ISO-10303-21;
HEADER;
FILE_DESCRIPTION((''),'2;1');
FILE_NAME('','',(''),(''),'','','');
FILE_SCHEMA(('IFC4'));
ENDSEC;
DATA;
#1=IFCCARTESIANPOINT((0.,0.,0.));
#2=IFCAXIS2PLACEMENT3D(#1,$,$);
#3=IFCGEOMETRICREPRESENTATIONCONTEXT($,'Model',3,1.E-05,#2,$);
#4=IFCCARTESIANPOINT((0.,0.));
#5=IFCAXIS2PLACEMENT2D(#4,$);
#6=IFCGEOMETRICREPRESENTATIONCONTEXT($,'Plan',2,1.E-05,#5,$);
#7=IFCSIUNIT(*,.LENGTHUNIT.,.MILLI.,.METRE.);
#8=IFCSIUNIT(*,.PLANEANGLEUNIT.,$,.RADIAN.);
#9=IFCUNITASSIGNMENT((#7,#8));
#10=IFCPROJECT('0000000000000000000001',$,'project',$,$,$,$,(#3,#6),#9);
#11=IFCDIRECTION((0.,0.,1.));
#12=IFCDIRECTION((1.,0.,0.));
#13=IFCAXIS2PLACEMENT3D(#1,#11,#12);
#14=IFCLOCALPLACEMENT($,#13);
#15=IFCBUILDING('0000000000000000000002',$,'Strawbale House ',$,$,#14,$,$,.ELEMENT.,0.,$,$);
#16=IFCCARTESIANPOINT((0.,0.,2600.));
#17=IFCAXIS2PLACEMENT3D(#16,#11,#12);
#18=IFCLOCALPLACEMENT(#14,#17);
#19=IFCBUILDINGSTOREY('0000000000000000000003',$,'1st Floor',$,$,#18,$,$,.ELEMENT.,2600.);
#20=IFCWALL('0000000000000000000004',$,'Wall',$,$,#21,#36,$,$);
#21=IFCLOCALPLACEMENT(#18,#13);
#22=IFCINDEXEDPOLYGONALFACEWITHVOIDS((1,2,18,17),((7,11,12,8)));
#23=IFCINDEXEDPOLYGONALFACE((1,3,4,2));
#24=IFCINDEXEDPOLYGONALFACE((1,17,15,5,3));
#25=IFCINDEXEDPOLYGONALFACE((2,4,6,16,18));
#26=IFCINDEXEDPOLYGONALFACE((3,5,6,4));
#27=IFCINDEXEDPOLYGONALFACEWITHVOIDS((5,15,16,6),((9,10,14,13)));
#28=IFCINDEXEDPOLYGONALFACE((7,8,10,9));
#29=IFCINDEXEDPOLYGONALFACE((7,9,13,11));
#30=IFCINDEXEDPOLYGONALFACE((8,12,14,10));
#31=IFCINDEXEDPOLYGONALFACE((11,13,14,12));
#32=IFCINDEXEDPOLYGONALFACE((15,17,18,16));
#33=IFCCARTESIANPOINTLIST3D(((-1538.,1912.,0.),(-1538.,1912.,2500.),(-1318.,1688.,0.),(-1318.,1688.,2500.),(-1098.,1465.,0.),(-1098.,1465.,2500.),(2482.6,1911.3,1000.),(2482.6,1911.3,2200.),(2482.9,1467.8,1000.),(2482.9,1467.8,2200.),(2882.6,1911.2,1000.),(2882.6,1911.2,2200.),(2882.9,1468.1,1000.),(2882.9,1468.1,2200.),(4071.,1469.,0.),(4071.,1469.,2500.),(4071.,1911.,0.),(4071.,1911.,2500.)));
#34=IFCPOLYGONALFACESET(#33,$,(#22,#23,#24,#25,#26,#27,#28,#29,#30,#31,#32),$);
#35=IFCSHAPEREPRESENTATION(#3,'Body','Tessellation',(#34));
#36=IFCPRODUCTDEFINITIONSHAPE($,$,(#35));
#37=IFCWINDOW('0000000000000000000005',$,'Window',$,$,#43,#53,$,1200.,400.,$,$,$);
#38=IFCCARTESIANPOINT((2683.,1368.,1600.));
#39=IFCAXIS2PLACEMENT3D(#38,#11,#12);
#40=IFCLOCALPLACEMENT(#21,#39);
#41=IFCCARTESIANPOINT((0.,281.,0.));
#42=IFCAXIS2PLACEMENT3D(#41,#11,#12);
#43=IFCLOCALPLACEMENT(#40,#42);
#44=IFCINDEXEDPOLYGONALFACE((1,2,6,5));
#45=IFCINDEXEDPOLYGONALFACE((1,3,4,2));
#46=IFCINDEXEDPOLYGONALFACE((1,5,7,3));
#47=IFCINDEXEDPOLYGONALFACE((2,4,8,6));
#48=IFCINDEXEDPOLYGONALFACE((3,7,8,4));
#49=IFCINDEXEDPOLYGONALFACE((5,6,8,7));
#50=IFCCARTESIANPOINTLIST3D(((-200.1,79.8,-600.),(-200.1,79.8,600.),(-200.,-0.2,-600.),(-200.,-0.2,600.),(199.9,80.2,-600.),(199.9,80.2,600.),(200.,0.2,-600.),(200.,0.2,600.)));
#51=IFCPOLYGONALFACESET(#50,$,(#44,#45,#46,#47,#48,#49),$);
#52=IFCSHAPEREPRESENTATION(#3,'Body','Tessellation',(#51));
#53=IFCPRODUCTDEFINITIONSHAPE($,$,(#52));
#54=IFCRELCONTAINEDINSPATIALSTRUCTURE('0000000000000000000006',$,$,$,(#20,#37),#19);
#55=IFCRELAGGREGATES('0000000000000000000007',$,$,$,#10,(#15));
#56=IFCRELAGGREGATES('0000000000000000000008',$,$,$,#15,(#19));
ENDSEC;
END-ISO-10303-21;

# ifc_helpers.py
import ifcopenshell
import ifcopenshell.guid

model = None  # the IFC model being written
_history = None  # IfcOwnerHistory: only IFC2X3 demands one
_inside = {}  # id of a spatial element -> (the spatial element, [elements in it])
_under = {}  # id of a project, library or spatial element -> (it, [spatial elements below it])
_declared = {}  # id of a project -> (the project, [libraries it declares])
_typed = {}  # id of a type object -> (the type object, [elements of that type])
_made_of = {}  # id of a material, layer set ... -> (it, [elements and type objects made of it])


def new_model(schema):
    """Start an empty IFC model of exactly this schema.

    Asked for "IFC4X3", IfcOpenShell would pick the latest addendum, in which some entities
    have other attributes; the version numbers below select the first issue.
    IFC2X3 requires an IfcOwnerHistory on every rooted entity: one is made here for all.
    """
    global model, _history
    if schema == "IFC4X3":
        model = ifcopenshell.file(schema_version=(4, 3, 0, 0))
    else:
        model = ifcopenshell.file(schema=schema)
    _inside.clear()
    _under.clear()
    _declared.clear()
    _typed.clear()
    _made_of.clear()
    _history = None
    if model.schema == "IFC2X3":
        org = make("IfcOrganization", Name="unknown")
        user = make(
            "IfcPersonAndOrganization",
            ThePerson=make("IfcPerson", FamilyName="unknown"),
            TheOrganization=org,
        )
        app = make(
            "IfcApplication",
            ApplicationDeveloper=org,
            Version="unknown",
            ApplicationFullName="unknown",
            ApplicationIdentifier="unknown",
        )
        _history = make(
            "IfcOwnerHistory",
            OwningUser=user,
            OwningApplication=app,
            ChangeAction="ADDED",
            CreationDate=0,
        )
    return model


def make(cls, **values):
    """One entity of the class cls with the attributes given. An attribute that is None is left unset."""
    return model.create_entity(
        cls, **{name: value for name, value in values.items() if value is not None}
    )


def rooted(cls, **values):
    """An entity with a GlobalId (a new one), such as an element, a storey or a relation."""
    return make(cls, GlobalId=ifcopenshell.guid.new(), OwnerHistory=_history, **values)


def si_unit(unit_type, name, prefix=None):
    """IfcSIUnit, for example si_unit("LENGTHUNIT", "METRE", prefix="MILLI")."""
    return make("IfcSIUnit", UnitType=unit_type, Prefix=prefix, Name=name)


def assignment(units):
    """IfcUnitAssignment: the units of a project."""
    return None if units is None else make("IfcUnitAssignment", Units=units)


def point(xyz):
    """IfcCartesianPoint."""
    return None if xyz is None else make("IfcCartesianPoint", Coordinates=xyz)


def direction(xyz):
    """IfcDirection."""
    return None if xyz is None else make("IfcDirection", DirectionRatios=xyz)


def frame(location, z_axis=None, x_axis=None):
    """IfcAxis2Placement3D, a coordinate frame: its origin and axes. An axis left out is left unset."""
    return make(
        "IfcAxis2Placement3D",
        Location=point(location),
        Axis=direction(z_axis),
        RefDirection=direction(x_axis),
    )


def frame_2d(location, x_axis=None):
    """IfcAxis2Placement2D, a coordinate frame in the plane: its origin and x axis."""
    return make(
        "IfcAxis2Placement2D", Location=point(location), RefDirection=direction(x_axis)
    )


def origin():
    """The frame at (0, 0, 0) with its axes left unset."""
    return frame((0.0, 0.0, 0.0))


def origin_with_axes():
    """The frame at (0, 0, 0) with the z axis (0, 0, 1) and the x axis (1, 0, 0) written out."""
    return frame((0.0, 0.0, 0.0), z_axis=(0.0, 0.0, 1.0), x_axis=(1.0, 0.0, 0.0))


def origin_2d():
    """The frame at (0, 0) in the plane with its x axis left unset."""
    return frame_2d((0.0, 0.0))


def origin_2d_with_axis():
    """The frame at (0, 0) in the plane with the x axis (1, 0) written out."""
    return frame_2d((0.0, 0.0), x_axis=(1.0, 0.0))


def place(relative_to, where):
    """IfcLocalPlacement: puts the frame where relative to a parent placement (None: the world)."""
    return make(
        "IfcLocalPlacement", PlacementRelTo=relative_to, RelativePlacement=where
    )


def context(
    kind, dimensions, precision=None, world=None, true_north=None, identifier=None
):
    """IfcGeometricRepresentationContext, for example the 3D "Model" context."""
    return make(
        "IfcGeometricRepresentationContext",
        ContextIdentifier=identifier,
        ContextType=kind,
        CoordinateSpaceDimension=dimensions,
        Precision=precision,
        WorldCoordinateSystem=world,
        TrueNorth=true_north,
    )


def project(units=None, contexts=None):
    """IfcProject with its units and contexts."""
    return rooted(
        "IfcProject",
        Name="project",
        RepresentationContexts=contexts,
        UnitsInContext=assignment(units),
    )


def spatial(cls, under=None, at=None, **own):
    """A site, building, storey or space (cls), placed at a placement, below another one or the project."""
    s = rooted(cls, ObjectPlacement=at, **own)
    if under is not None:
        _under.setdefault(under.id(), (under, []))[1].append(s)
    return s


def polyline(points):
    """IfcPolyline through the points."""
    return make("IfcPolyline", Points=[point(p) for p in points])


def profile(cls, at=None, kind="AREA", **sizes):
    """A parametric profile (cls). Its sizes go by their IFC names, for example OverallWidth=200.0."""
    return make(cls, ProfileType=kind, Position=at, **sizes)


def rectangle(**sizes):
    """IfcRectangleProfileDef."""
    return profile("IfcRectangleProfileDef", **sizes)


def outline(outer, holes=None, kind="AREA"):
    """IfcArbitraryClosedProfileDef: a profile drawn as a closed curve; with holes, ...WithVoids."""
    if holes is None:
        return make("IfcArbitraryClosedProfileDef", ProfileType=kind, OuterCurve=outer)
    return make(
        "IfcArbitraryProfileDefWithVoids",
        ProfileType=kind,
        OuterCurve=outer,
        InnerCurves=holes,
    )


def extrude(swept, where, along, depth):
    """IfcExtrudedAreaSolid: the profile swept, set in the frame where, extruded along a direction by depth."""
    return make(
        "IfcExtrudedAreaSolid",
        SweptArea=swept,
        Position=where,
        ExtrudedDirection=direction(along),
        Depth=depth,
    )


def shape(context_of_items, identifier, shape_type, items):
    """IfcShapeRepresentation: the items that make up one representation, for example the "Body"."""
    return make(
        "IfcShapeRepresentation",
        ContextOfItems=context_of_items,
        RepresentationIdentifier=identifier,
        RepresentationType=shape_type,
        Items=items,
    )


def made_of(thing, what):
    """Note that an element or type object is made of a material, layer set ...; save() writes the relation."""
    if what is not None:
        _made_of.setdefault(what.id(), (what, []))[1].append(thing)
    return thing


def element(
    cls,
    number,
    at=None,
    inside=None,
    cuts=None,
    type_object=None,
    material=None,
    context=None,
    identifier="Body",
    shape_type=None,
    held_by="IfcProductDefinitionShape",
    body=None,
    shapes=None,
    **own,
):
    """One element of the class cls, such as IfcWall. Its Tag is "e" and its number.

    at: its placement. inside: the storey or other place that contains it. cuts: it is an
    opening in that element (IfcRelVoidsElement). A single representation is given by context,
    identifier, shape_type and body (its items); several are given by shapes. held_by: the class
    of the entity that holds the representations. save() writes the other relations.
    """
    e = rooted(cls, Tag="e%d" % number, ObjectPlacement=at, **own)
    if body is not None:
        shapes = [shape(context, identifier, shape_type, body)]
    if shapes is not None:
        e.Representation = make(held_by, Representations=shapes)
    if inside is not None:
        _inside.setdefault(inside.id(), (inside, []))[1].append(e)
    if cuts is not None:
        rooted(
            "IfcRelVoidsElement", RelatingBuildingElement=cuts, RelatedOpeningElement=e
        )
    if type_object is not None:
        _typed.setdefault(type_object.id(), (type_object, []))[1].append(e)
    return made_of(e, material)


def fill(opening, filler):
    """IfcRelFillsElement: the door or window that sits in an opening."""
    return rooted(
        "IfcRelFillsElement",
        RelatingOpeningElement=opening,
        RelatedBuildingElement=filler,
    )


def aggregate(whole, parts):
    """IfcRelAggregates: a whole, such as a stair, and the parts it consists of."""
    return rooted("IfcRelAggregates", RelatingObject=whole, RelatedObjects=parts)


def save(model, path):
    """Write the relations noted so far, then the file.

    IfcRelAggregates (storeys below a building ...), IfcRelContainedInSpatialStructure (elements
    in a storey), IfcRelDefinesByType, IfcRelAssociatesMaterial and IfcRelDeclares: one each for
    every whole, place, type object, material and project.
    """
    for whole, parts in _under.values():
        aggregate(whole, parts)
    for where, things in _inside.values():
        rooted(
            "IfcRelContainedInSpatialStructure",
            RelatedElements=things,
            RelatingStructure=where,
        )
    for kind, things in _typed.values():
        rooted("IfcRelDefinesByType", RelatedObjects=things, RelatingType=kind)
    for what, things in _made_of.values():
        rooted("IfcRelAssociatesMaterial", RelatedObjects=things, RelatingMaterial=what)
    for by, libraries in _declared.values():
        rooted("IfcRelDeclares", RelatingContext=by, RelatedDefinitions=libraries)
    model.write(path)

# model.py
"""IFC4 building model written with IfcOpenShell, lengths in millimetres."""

from ifc_helpers import new_model, si_unit, frame, origin, origin_with_axes, origin_2d, origin_2d_with_axis, place, context, project, spatial, polyline, rectangle, outline, extrude, element, fill, save


model = new_model("IFC4")

# Units and contexts
model_context = context("Model", 3, precision=1e-05, world=origin())
plan_context = context("Plan", 2, precision=1e-05, world=origin_2d())
ifc_project = project(units=[si_unit("LENGTHUNIT", "METRE", prefix="MILLI"), si_unit("PLANEANGLEUNIT", "RADIAN")], contexts=[model_context, plan_context])

# Building, storey
building_placement = place(None, origin_with_axes())
building = spatial("IfcBuilding", under=ifc_project, at=building_placement, Name="Strawbale House ", CompositionType="ELEMENT", ElevationOfRefHeight=0.0)
storey_placement = place(building_placement, frame((0.0, 0.0, 2600.0), z_axis=(0.0, 0.0, 1.0), x_axis=(1.0, 0.0, 0.0)))
storey = spatial("IfcBuildingStorey", under=building, at=storey_placement, Name="1st Floor", CompositionType="ELEMENT", Elevation=2600.0)

# Wall, opening, window
wall_1_placement = place(storey_placement, origin_with_axes())
wall_1 = element("IfcWall", 1, at=wall_1_placement, inside=storey, Name="Wall", context=model_context, shape_type="SweptSolid", body=[
    extrude(outline(polyline([(4071.0, 1690.0, 0.0), (4071.0, 1469.0, 0.0), (-1098.0, 1465.0, 0.0), (-1318.0, 1688.0, 0.0), (-1538.0, 1912.0, 0.0), (4071.0, 1911.0, 0.0), (4071.0, 1690.0, 0.0)])), origin_with_axes(), (0.0, 0.0, 1.0), 2500.0),
])
opening_1_placement = place(wall_1_placement, frame((2683.0, 1368.0, 1600.0), z_axis=(0.0, 0.0, 1.0), x_axis=(1.0, 0.0, 0.0)))
opening_1 = element("IfcOpeningElement", 2, at=opening_1_placement, cuts=wall_1, PredefinedType="OPENING", context=model_context, shape_type="SweptSolid", body=[
    extrude(rectangle(XDim=400.0, YDim=1200.0, at=origin_2d_with_axis()), frame((0.0, 0.0, 0.0), z_axis=(-4.0, 5169.0, 0.0), x_axis=(-5169.0, -4.0, 0.0)), (0.0, 0.0, 1.0), 642.4),
])
window_1_placement = place(opening_1_placement, frame((0.0, 281.0, 0.0), z_axis=(0.0, 0.0, 1.0), x_axis=(1.0, 0.0, 0.0)))
window_1 = element("IfcWindow", 3, at=window_1_placement, inside=storey, Name="Window", OverallHeight=1200.0, OverallWidth=400.0, context=model_context, shape_type="SweptSolid", body=[
    extrude(outline(polyline([(200.0, 600.0, 0.0), (200.0, -600.0, 0.0), (-200.0, -600.0, 0.0), (-200.0, 600.0, 0.0), (200.0, 600.0, 0.0)])), frame((0.0, 0.0, 0.0), z_axis=(-4.0, 5169.0, 0.0), x_axis=(-5169.0, -4.0, 0.0)), (0.0, 0.0, 1.0), 80.0),
])
fill(opening_1, window_1)

save(model, "model.ifc")
